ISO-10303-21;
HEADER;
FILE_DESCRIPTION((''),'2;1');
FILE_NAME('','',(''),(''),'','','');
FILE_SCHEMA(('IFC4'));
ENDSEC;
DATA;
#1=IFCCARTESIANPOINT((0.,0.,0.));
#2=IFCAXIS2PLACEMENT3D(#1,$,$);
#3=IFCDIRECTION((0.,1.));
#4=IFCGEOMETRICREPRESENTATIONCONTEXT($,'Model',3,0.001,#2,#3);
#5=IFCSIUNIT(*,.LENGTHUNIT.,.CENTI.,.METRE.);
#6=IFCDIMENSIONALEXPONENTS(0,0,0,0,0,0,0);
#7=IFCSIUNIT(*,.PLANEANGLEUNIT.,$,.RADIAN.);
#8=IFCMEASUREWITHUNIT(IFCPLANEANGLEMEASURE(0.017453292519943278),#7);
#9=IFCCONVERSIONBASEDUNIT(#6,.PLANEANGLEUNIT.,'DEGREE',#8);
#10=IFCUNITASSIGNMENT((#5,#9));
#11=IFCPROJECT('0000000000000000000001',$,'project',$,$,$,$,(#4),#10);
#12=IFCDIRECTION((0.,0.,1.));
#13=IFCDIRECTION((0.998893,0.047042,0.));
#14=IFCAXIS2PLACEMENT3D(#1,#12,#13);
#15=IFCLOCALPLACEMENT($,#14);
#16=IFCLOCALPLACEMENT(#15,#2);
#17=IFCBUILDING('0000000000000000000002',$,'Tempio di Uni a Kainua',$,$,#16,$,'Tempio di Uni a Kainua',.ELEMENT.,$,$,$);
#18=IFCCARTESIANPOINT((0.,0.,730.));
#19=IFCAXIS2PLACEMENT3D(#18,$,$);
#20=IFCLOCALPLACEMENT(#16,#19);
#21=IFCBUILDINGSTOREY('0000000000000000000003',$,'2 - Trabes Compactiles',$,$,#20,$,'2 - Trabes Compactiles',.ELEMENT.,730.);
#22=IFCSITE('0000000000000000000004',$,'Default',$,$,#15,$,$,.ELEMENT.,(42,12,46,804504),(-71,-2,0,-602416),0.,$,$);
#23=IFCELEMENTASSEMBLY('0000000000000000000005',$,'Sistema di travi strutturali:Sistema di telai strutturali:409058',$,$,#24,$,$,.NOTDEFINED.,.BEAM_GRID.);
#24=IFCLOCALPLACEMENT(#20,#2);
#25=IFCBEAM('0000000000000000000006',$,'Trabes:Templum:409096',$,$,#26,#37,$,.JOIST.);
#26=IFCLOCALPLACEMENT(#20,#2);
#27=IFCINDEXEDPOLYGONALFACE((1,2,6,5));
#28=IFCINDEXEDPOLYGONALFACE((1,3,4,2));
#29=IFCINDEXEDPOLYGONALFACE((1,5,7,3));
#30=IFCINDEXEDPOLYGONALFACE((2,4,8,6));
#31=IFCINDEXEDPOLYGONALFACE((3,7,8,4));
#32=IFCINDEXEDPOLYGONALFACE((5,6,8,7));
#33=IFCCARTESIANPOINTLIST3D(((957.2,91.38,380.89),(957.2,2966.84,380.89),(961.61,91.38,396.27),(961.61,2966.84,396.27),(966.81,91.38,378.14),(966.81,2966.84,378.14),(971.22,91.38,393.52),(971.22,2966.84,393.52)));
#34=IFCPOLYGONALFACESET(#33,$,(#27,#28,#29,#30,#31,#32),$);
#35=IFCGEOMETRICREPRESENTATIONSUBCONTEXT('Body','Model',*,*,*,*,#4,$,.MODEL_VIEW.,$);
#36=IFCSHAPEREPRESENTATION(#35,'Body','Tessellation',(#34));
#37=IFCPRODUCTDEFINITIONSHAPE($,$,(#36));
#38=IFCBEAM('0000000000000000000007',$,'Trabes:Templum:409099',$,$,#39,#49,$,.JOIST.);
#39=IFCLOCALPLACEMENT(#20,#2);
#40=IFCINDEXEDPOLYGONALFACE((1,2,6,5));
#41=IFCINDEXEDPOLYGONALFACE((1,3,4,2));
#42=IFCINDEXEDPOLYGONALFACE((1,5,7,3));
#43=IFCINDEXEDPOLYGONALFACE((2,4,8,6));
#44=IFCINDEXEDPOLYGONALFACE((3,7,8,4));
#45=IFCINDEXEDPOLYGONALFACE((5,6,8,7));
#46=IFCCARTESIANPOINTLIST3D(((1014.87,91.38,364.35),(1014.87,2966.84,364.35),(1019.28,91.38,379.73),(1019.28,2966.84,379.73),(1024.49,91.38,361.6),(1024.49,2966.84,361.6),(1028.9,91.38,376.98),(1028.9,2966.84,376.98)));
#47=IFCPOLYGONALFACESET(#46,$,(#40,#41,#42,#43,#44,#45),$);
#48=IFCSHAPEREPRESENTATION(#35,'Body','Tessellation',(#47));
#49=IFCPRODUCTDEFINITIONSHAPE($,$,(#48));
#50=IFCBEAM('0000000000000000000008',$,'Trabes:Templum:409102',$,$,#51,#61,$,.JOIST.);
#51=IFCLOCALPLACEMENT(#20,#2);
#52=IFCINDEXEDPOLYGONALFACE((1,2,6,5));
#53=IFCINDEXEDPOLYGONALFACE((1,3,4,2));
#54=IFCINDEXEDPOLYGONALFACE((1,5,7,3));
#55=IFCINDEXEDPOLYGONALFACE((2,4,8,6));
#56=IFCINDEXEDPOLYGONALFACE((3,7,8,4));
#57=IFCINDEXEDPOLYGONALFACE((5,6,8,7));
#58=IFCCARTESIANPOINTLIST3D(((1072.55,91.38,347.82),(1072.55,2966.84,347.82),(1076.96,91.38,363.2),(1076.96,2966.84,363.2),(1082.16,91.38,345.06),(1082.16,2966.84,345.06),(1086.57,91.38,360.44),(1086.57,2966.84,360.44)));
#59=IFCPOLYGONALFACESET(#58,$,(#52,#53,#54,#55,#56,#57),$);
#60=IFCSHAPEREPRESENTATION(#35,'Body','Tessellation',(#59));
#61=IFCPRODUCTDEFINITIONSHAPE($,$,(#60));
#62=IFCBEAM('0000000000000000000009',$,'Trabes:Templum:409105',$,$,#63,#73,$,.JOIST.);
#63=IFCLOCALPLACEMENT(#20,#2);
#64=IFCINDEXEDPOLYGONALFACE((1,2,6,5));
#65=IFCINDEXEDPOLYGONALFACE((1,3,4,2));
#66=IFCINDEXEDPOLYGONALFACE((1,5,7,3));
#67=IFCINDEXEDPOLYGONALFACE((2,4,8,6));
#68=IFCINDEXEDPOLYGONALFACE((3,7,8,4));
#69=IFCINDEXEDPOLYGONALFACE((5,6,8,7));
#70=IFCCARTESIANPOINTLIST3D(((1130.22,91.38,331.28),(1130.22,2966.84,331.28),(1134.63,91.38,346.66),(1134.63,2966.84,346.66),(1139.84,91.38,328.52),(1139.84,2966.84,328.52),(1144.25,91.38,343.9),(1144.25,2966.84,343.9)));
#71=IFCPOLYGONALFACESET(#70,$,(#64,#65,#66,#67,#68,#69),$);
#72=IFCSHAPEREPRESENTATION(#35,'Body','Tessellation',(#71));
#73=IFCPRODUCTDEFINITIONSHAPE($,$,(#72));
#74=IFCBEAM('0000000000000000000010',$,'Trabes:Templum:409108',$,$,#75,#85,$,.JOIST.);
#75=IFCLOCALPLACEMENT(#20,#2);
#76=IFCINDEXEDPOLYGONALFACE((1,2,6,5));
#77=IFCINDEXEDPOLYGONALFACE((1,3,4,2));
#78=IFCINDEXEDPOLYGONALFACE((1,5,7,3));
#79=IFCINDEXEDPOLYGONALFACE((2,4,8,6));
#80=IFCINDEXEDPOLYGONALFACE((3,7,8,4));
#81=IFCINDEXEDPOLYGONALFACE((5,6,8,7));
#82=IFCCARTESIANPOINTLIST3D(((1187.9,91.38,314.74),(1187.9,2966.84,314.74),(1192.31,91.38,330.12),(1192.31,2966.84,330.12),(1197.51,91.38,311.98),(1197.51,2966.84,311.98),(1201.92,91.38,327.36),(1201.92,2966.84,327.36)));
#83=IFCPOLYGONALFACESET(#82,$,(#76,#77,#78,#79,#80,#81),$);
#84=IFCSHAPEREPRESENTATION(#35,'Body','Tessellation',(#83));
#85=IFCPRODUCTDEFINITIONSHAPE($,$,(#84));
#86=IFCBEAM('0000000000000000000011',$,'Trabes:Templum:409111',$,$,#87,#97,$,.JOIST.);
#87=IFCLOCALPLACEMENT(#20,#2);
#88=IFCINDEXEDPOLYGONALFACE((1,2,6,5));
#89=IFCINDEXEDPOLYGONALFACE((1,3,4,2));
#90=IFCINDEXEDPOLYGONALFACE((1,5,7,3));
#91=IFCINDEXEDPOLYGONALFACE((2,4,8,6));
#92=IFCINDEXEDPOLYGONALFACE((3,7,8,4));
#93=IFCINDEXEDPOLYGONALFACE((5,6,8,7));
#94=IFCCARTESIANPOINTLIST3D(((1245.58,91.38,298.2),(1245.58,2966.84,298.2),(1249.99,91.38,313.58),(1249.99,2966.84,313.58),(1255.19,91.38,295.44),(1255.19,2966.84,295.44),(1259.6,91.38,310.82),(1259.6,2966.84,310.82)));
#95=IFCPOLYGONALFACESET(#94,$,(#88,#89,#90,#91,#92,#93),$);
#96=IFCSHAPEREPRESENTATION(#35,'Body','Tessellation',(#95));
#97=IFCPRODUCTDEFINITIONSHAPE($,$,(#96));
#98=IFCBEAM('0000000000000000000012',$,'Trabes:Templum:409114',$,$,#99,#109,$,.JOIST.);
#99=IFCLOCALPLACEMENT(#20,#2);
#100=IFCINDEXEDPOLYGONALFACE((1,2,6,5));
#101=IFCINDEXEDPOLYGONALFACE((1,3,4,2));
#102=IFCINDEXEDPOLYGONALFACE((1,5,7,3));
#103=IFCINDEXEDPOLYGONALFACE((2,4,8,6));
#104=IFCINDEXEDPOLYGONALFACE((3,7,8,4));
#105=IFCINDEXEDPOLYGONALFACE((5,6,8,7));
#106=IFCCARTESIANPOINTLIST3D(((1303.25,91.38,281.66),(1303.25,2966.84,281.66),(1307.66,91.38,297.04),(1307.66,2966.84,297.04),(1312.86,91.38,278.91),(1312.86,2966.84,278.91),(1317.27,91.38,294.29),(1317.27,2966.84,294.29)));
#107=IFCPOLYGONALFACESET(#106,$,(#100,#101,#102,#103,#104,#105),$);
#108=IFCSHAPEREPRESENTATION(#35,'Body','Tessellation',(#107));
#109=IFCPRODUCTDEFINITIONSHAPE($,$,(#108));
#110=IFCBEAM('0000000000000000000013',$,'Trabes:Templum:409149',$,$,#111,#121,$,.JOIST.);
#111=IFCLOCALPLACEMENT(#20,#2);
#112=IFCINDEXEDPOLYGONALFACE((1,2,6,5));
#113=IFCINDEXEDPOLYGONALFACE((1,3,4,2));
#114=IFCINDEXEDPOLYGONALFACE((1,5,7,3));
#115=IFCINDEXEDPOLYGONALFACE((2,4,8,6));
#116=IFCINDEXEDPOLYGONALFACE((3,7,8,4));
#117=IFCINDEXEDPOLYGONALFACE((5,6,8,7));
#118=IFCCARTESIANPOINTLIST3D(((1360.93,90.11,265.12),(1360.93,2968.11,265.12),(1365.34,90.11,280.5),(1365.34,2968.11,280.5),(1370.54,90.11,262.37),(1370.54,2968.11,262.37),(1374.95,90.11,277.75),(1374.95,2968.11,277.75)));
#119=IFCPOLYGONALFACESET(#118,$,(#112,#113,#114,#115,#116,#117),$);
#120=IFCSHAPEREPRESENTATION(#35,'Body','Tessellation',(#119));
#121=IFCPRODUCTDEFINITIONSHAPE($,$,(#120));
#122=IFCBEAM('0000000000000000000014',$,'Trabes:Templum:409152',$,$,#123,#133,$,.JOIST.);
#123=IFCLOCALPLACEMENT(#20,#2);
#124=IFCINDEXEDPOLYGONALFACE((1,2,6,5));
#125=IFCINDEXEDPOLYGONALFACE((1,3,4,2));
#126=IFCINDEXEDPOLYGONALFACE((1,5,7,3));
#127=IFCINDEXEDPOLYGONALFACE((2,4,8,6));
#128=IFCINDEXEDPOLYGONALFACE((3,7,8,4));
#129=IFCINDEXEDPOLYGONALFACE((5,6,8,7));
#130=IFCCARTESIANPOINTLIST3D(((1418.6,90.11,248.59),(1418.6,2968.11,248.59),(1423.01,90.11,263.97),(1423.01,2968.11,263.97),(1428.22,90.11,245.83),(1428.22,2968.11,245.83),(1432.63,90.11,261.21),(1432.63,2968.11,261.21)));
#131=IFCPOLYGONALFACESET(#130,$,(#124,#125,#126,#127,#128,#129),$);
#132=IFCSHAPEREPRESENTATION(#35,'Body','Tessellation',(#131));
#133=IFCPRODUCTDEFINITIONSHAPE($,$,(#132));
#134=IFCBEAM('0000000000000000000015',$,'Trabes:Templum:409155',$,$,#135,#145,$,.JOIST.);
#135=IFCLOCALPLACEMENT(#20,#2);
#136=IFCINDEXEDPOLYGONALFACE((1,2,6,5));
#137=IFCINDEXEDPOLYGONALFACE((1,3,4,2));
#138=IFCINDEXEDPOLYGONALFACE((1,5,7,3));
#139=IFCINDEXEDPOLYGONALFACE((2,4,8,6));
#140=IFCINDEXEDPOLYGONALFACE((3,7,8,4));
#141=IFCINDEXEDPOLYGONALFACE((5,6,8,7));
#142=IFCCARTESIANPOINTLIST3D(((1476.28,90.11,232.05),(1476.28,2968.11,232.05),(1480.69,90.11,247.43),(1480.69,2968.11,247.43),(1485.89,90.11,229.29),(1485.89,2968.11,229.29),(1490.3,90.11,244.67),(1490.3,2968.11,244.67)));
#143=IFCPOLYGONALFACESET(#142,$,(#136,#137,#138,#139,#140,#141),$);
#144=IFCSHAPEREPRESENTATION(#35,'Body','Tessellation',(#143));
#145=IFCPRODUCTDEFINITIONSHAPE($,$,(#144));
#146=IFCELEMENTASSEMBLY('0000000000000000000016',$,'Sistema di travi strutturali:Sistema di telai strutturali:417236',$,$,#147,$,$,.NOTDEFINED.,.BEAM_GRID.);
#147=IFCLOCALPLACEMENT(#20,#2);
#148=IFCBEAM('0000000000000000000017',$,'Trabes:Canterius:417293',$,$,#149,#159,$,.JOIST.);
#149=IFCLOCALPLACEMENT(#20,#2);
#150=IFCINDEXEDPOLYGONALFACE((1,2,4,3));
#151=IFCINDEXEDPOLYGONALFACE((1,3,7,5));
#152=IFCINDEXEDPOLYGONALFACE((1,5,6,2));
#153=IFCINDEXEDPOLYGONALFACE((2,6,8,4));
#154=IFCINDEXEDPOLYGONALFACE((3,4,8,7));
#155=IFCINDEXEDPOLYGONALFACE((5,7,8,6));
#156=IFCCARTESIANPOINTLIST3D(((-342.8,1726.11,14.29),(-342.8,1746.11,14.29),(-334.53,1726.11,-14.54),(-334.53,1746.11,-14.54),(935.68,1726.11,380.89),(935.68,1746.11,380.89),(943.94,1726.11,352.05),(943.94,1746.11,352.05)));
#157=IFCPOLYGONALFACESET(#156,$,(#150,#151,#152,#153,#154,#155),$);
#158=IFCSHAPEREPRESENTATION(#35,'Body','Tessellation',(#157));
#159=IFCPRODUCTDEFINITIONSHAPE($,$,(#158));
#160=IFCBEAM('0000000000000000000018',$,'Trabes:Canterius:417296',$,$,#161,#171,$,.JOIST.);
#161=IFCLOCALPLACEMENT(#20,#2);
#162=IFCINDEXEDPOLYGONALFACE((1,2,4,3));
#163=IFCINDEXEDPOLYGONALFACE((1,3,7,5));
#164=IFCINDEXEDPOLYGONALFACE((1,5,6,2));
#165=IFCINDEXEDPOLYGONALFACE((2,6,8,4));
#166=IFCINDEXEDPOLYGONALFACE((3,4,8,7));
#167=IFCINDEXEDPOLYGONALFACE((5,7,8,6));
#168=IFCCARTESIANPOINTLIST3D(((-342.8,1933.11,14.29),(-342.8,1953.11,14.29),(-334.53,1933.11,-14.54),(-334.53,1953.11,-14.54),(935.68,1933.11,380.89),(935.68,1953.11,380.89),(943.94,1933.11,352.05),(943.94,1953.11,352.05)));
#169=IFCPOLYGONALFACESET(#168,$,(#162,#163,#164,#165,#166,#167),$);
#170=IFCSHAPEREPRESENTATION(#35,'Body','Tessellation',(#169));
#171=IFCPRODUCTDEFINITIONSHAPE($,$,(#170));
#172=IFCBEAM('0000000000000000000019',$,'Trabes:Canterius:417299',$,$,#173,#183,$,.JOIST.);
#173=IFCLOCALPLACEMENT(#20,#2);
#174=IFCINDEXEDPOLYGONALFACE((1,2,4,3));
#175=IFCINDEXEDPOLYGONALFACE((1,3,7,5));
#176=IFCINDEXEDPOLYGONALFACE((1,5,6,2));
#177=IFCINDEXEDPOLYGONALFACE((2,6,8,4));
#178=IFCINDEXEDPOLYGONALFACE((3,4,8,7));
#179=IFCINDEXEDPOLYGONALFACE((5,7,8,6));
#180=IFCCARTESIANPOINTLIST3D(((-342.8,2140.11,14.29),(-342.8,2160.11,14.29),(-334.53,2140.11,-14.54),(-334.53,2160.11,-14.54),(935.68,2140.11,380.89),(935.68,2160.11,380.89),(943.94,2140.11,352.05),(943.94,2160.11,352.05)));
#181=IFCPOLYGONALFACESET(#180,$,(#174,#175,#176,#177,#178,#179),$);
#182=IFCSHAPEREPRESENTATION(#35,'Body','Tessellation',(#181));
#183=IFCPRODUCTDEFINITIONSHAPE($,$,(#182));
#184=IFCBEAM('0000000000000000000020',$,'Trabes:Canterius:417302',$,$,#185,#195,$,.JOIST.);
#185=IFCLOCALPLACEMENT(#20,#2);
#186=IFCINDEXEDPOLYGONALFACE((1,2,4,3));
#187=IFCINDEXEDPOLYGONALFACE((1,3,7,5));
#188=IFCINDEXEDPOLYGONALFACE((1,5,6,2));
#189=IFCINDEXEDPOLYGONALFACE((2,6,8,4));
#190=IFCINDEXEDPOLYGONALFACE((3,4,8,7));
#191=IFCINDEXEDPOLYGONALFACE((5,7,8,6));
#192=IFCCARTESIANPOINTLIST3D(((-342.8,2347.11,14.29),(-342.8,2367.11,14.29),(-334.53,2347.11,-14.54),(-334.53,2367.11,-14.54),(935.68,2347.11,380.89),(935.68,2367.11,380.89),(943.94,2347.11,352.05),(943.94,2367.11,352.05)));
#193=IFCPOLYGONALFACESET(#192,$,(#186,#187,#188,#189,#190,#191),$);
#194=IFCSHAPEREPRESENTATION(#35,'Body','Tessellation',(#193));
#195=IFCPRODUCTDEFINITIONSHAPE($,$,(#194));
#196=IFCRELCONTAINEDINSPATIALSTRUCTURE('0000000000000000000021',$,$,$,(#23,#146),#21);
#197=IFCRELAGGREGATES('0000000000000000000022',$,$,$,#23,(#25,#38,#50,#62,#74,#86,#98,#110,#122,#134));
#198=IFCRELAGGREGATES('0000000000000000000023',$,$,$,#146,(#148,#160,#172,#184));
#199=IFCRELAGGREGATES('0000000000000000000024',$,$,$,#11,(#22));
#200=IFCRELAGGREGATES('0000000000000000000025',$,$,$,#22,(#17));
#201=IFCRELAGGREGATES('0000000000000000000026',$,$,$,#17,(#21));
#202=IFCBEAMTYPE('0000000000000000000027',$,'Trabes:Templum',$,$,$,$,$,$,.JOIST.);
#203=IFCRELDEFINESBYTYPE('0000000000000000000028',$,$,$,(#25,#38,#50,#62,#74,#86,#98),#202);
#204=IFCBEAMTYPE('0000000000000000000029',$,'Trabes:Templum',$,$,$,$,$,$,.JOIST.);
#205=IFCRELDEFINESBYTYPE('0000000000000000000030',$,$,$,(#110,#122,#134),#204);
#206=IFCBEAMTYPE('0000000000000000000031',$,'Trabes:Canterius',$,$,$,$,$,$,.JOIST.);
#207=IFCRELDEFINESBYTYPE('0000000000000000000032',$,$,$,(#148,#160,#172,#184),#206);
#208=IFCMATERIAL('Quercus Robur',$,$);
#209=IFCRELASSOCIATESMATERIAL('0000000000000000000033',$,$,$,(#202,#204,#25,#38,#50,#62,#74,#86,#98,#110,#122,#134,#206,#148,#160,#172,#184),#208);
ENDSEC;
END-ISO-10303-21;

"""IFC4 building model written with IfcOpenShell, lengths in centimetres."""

from ifc_helpers import new_model, entity, si_unit, converted_unit, direction, frame, frame_2d, origin, origin_2d_with_axis, place, context, subcontext, project, spatial, rectangle, extrude, source, transform, mapped, material, material_profile, profile_set, profile_usage, type_object, type_shapes, element, aggregate, save


model = new_model("IFC4")

# Units and contexts
model_context = context("Model", 3, precision=0.001, world=origin(), true_north=direction((0.0, 1.0)))
body_context = subcontext(model_context, "Body", "Model", "MODEL_VIEW")
ifc_project = project(units=[si_unit("LENGTHUNIT", "METRE", prefix="CENTI"), converted_unit("PLANEANGLEUNIT", "DEGREE", entity("IfcPlaneAngleMeasure", 0.017453292519943278), si_unit("PLANEANGLEUNIT", "RADIAN"), dimensions=[0, 0, 0, 0, 0, 0, 0])], contexts=[model_context])

# Site, building, storey
site_placement = place(None, frame((0.0, 0.0, 0.0), z_axis=(0.0, 0.0, 1.0), x_axis=(0.998893, 0.047042, 0.0)))
site = spatial("IfcSite", under=ifc_project, at=site_placement, Name="Default", CompositionType="ELEMENT", RefLatitude=(42, 12, 46, 804504), RefLongitude=(-71, -2, 0, -602416), RefElevation=0.0)
building_placement = place(site_placement, origin())
building = spatial("IfcBuilding", under=site, at=building_placement, Name="Tempio di Uni a Kainua", LongName="Tempio di Uni a Kainua", CompositionType="ELEMENT")
storey_placement = place(building_placement, frame((0.0, 0.0, 730.0)))
storey = spatial("IfcBuildingStorey", under=building, at=storey_placement, Name="2 - Trabes Compactiles", LongName="2 - Trabes Compactiles", CompositionType="ELEMENT", Elevation=730.0)

# Shared definitions
ifc_material = material(Name="Quercus Robur")

# Element assemblies, beams
assembly_1_placement = place(storey_placement, origin())
assembly_1 = element("IfcElementAssembly", 1, at=assembly_1_placement, inside=storey, Name="Sistema di travi strutturali:Sistema di telai strutturali:409058", AssemblyPlace="NOTDEFINED", PredefinedType="BEAM_GRID")
ifc_material_profile_1 = material_profile(ifc_material, rectangle(XDim=2875.46, YDim=10.0, at=origin_2d_with_axis()), Name="Templum")
ifc_profile_set_1 = profile_set([ifc_material_profile_1], Name="Templum")
ifc_profile_usage_1 = profile_usage(ifc_profile_set_1, cardinal=2)
beam_type_1 = type_object("IfcBeamType", Name="Trabes:Templum", PredefinedType="JOIST", material=ifc_profile_set_1)
shared_shape_1 = source(origin(), body_context, "Body", "SweptSolid", [
    extrude(rectangle(XDim=2875.46, YDim=10.0, at=origin_2d_with_axis()), frame((0.0, 0.0, -8.0)), (0.0, 0.0, 1.0), 16.0),
])
type_shapes(beam_type_1, [shared_shape_1])
beam_1_placement = place(assembly_1_placement, frame((964.21, 1529.11, 387.2), z_axis=(0.275637, 0.0, 0.961262), x_axis=(0.0, 1.0, 0.0)))
beam_1 = element("IfcBeam", 2, at=beam_1_placement, type_object=beam_type_1, material=ifc_profile_usage_1, Name="Trabes:Templum:409096", PredefinedType="JOIST", context=body_context, shape_type="MappedRepresentation", body=[
    mapped(shared_shape_1, transform((0.0, 0.0, 0.0), scale=1.0)),
])
beam_2_placement = place(assembly_1_placement, frame((1021.88, 1529.11, 370.67), z_axis=(0.275637, 0.0, 0.961262), x_axis=(0.0, 1.0, 0.0)))
beam_2 = element("IfcBeam", 3, at=beam_2_placement, type_object=beam_type_1, material=ifc_profile_usage_1, Name="Trabes:Templum:409099", PredefinedType="JOIST", context=body_context, shape_type="MappedRepresentation", body=[
    mapped(shared_shape_1, transform((0.0, 0.0, 0.0), scale=1.0)),
])
beam_3_placement = place(assembly_1_placement, frame((1079.56, 1529.11, 354.13), z_axis=(0.275637, 0.0, 0.961262), x_axis=(0.0, 1.0, 0.0)))
beam_3 = element("IfcBeam", 4, at=beam_3_placement, type_object=beam_type_1, material=ifc_profile_usage_1, Name="Trabes:Templum:409102", PredefinedType="JOIST", context=body_context, shape_type="MappedRepresentation", body=[
    mapped(shared_shape_1, transform((0.0, 0.0, 0.0), scale=1.0)),
])
beam_4_placement = place(assembly_1_placement, frame((1137.24, 1529.11, 337.59), z_axis=(0.275637, 0.0, 0.961262), x_axis=(0.0, 1.0, 0.0)))
beam_4 = element("IfcBeam", 5, at=beam_4_placement, type_object=beam_type_1, material=ifc_profile_usage_1, Name="Trabes:Templum:409105", PredefinedType="JOIST", context=body_context, shape_type="MappedRepresentation", body=[
    mapped(shared_shape_1, transform((0.0, 0.0, 0.0), scale=1.0)),
])
beam_5_placement = place(assembly_1_placement, frame((1194.91, 1529.11, 321.05), z_axis=(0.275637, 0.0, 0.961262), x_axis=(0.0, 1.0, 0.0)))
beam_5 = element("IfcBeam", 6, at=beam_5_placement, type_object=beam_type_1, material=ifc_profile_usage_1, Name="Trabes:Templum:409108", PredefinedType="JOIST", context=body_context, shape_type="MappedRepresentation", body=[
    mapped(shared_shape_1, transform((0.0, 0.0, 0.0), scale=1.0)),
])
beam_6_placement = place(assembly_1_placement, frame((1252.59, 1529.11, 304.51), z_axis=(0.275637, 0.0, 0.961262), x_axis=(0.0, 1.0, 0.0)))
beam_6 = element("IfcBeam", 7, at=beam_6_placement, type_object=beam_type_1, material=ifc_profile_usage_1, Name="Trabes:Templum:409111", PredefinedType="JOIST", context=body_context, shape_type="MappedRepresentation", body=[
    mapped(shared_shape_1, transform((0.0, 0.0, 0.0), scale=1.0)),
])
beam_7_placement = place(assembly_1_placement, frame((1310.26, 1529.11, 287.97), z_axis=(0.275637, 0.0, 0.961262), x_axis=(0.0, 1.0, 0.0)))
beam_7 = element("IfcBeam", 8, at=beam_7_placement, type_object=beam_type_1, material=ifc_profile_usage_1, Name="Trabes:Templum:409114", PredefinedType="JOIST", context=body_context, shape_type="MappedRepresentation", body=[
    mapped(shared_shape_1, transform((0.0, 0.0, 0.0), scale=1.0)),
])
beam_type_2 = type_object("IfcBeamType", Name="Trabes:Templum", PredefinedType="JOIST", material=ifc_profile_set_1)
shared_shape_2 = source(origin(), body_context, "Body", "SweptSolid", [
    extrude(rectangle(XDim=2878.0, YDim=10.0, at=frame_2d((0.0, 0.0), x_axis=(1.0, 0.0))), frame((0.0, 0.0, -8.0)), (0.0, 0.0, 1.0), 16.0),
])
type_shapes(beam_type_2, [shared_shape_2])
beam_8_placement = place(assembly_1_placement, frame((1367.94, 1529.11, 271.44), z_axis=(0.275637, 0.0, 0.961262), x_axis=(0.0, 1.0, 0.0)))
beam_8 = element("IfcBeam", 9, at=beam_8_placement, type_object=beam_type_2, material=ifc_profile_usage_1, Name="Trabes:Templum:409149", PredefinedType="JOIST", context=body_context, shape_type="MappedRepresentation", body=[
    mapped(shared_shape_2, transform((0.0, 0.0, 0.0), scale=1.0)),
])
beam_9_placement = place(assembly_1_placement, frame((1425.61, 1529.11, 254.9), z_axis=(0.275637, 0.0, 0.961262), x_axis=(0.0, 1.0, 0.0)))
beam_9 = element("IfcBeam", 10, at=beam_9_placement, type_object=beam_type_2, material=ifc_profile_usage_1, Name="Trabes:Templum:409152", PredefinedType="JOIST", context=body_context, shape_type="MappedRepresentation", body=[
    mapped(shared_shape_2, transform((0.0, 0.0, 0.0), scale=1.0)),
])
beam_10_placement = place(assembly_1_placement, frame((1483.29, 1529.11, 238.36), z_axis=(0.275637, 0.0, 0.961262), x_axis=(0.0, 1.0, 0.0)))
beam_10 = element("IfcBeam", 11, at=beam_10_placement, type_object=beam_type_2, material=ifc_profile_usage_1, Name="Trabes:Templum:409155", PredefinedType="JOIST", context=body_context, shape_type="MappedRepresentation", body=[
    mapped(shared_shape_2, transform((0.0, 0.0, 0.0), scale=1.0)),
])
aggregate(assembly_1, [beam_1, beam_2, beam_3, beam_4, beam_5, beam_6, beam_7, beam_8, beam_9, beam_10])
assembly_2_placement = place(storey_placement, origin())
assembly_2 = element("IfcElementAssembly", 12, at=assembly_2_placement, inside=storey, Name="Sistema di travi strutturali:Sistema di telai strutturali:417236", AssemblyPlace="NOTDEFINED", PredefinedType="BEAM_GRID")
ifc_material_profile_2 = material_profile(ifc_material, rectangle(XDim=2590.0, YDim=20.0, at=origin_2d_with_axis()), Name="Canterius")
ifc_profile_set_2 = profile_set([ifc_material_profile_2], Name="Canterius")
ifc_profile_usage_2 = profile_usage(ifc_profile_set_2, cardinal=8)
beam_type_3 = type_object("IfcBeamType", Name="Trabes:Canterius", PredefinedType="JOIST", material=ifc_profile_set_2)
shared_shape_3 = source(origin(), body_context, "Body", "SweptSolid", [
    extrude(rectangle(XDim=1330.0, YDim=20.0, at=origin_2d_with_axis()), frame((0.0, 0.0, -15.0)), (0.0, 0.0, 1.0), 30.0),
])
type_shapes(beam_type_3, [shared_shape_3])
beam_11_placement = place(assembly_2_placement, frame((300.57, 1736.11, 183.17), z_axis=(-0.275637, 0.0, 0.961262), x_axis=(0.961262, 0.0, 0.275637)))
beam_11 = element("IfcBeam", 13, at=beam_11_placement, type_object=beam_type_3, material=ifc_profile_usage_2, Name="Trabes:Canterius:417293", PredefinedType="JOIST", context=body_context, shape_type="MappedRepresentation", body=[
    mapped(shared_shape_3, transform((0.0, 0.0, 0.0), scale=1.0)),
])
beam_12_placement = place(assembly_2_placement, frame((300.57, 1943.11, 183.17), z_axis=(-0.275637, 0.0, 0.961262), x_axis=(0.961262, 0.0, 0.275637)))
beam_12 = element("IfcBeam", 14, at=beam_12_placement, type_object=beam_type_3, material=ifc_profile_usage_2, Name="Trabes:Canterius:417296", PredefinedType="JOIST", context=body_context, shape_type="MappedRepresentation", body=[
    mapped(shared_shape_3, transform((0.0, 0.0, 0.0), scale=1.0)),
])
beam_13_placement = place(assembly_2_placement, frame((300.57, 2150.11, 183.17), z_axis=(-0.275637, 0.0, 0.961262), x_axis=(0.961262, 0.0, 0.275637)))
beam_13 = element("IfcBeam", 15, at=beam_13_placement, type_object=beam_type_3, material=ifc_profile_usage_2, Name="Trabes:Canterius:417299", PredefinedType="JOIST", context=body_context, shape_type="MappedRepresentation", body=[
    mapped(shared_shape_3, transform((0.0, 0.0, 0.0), scale=1.0)),
])
beam_14_placement = place(assembly_2_placement, frame((300.57, 2357.11, 183.17), z_axis=(-0.275637, 0.0, 0.961262), x_axis=(0.961262, 0.0, 0.275637)))
beam_14 = element("IfcBeam", 16, at=beam_14_placement, type_object=beam_type_3, material=ifc_profile_usage_2, Name="Trabes:Canterius:417302", PredefinedType="JOIST", context=body_context, shape_type="MappedRepresentation", body=[
    mapped(shared_shape_3, transform((0.0, 0.0, 0.0), scale=1.0)),
])
aggregate(assembly_2, [beam_11, beam_12, beam_13, beam_14])

save(model, "model.ifc")
